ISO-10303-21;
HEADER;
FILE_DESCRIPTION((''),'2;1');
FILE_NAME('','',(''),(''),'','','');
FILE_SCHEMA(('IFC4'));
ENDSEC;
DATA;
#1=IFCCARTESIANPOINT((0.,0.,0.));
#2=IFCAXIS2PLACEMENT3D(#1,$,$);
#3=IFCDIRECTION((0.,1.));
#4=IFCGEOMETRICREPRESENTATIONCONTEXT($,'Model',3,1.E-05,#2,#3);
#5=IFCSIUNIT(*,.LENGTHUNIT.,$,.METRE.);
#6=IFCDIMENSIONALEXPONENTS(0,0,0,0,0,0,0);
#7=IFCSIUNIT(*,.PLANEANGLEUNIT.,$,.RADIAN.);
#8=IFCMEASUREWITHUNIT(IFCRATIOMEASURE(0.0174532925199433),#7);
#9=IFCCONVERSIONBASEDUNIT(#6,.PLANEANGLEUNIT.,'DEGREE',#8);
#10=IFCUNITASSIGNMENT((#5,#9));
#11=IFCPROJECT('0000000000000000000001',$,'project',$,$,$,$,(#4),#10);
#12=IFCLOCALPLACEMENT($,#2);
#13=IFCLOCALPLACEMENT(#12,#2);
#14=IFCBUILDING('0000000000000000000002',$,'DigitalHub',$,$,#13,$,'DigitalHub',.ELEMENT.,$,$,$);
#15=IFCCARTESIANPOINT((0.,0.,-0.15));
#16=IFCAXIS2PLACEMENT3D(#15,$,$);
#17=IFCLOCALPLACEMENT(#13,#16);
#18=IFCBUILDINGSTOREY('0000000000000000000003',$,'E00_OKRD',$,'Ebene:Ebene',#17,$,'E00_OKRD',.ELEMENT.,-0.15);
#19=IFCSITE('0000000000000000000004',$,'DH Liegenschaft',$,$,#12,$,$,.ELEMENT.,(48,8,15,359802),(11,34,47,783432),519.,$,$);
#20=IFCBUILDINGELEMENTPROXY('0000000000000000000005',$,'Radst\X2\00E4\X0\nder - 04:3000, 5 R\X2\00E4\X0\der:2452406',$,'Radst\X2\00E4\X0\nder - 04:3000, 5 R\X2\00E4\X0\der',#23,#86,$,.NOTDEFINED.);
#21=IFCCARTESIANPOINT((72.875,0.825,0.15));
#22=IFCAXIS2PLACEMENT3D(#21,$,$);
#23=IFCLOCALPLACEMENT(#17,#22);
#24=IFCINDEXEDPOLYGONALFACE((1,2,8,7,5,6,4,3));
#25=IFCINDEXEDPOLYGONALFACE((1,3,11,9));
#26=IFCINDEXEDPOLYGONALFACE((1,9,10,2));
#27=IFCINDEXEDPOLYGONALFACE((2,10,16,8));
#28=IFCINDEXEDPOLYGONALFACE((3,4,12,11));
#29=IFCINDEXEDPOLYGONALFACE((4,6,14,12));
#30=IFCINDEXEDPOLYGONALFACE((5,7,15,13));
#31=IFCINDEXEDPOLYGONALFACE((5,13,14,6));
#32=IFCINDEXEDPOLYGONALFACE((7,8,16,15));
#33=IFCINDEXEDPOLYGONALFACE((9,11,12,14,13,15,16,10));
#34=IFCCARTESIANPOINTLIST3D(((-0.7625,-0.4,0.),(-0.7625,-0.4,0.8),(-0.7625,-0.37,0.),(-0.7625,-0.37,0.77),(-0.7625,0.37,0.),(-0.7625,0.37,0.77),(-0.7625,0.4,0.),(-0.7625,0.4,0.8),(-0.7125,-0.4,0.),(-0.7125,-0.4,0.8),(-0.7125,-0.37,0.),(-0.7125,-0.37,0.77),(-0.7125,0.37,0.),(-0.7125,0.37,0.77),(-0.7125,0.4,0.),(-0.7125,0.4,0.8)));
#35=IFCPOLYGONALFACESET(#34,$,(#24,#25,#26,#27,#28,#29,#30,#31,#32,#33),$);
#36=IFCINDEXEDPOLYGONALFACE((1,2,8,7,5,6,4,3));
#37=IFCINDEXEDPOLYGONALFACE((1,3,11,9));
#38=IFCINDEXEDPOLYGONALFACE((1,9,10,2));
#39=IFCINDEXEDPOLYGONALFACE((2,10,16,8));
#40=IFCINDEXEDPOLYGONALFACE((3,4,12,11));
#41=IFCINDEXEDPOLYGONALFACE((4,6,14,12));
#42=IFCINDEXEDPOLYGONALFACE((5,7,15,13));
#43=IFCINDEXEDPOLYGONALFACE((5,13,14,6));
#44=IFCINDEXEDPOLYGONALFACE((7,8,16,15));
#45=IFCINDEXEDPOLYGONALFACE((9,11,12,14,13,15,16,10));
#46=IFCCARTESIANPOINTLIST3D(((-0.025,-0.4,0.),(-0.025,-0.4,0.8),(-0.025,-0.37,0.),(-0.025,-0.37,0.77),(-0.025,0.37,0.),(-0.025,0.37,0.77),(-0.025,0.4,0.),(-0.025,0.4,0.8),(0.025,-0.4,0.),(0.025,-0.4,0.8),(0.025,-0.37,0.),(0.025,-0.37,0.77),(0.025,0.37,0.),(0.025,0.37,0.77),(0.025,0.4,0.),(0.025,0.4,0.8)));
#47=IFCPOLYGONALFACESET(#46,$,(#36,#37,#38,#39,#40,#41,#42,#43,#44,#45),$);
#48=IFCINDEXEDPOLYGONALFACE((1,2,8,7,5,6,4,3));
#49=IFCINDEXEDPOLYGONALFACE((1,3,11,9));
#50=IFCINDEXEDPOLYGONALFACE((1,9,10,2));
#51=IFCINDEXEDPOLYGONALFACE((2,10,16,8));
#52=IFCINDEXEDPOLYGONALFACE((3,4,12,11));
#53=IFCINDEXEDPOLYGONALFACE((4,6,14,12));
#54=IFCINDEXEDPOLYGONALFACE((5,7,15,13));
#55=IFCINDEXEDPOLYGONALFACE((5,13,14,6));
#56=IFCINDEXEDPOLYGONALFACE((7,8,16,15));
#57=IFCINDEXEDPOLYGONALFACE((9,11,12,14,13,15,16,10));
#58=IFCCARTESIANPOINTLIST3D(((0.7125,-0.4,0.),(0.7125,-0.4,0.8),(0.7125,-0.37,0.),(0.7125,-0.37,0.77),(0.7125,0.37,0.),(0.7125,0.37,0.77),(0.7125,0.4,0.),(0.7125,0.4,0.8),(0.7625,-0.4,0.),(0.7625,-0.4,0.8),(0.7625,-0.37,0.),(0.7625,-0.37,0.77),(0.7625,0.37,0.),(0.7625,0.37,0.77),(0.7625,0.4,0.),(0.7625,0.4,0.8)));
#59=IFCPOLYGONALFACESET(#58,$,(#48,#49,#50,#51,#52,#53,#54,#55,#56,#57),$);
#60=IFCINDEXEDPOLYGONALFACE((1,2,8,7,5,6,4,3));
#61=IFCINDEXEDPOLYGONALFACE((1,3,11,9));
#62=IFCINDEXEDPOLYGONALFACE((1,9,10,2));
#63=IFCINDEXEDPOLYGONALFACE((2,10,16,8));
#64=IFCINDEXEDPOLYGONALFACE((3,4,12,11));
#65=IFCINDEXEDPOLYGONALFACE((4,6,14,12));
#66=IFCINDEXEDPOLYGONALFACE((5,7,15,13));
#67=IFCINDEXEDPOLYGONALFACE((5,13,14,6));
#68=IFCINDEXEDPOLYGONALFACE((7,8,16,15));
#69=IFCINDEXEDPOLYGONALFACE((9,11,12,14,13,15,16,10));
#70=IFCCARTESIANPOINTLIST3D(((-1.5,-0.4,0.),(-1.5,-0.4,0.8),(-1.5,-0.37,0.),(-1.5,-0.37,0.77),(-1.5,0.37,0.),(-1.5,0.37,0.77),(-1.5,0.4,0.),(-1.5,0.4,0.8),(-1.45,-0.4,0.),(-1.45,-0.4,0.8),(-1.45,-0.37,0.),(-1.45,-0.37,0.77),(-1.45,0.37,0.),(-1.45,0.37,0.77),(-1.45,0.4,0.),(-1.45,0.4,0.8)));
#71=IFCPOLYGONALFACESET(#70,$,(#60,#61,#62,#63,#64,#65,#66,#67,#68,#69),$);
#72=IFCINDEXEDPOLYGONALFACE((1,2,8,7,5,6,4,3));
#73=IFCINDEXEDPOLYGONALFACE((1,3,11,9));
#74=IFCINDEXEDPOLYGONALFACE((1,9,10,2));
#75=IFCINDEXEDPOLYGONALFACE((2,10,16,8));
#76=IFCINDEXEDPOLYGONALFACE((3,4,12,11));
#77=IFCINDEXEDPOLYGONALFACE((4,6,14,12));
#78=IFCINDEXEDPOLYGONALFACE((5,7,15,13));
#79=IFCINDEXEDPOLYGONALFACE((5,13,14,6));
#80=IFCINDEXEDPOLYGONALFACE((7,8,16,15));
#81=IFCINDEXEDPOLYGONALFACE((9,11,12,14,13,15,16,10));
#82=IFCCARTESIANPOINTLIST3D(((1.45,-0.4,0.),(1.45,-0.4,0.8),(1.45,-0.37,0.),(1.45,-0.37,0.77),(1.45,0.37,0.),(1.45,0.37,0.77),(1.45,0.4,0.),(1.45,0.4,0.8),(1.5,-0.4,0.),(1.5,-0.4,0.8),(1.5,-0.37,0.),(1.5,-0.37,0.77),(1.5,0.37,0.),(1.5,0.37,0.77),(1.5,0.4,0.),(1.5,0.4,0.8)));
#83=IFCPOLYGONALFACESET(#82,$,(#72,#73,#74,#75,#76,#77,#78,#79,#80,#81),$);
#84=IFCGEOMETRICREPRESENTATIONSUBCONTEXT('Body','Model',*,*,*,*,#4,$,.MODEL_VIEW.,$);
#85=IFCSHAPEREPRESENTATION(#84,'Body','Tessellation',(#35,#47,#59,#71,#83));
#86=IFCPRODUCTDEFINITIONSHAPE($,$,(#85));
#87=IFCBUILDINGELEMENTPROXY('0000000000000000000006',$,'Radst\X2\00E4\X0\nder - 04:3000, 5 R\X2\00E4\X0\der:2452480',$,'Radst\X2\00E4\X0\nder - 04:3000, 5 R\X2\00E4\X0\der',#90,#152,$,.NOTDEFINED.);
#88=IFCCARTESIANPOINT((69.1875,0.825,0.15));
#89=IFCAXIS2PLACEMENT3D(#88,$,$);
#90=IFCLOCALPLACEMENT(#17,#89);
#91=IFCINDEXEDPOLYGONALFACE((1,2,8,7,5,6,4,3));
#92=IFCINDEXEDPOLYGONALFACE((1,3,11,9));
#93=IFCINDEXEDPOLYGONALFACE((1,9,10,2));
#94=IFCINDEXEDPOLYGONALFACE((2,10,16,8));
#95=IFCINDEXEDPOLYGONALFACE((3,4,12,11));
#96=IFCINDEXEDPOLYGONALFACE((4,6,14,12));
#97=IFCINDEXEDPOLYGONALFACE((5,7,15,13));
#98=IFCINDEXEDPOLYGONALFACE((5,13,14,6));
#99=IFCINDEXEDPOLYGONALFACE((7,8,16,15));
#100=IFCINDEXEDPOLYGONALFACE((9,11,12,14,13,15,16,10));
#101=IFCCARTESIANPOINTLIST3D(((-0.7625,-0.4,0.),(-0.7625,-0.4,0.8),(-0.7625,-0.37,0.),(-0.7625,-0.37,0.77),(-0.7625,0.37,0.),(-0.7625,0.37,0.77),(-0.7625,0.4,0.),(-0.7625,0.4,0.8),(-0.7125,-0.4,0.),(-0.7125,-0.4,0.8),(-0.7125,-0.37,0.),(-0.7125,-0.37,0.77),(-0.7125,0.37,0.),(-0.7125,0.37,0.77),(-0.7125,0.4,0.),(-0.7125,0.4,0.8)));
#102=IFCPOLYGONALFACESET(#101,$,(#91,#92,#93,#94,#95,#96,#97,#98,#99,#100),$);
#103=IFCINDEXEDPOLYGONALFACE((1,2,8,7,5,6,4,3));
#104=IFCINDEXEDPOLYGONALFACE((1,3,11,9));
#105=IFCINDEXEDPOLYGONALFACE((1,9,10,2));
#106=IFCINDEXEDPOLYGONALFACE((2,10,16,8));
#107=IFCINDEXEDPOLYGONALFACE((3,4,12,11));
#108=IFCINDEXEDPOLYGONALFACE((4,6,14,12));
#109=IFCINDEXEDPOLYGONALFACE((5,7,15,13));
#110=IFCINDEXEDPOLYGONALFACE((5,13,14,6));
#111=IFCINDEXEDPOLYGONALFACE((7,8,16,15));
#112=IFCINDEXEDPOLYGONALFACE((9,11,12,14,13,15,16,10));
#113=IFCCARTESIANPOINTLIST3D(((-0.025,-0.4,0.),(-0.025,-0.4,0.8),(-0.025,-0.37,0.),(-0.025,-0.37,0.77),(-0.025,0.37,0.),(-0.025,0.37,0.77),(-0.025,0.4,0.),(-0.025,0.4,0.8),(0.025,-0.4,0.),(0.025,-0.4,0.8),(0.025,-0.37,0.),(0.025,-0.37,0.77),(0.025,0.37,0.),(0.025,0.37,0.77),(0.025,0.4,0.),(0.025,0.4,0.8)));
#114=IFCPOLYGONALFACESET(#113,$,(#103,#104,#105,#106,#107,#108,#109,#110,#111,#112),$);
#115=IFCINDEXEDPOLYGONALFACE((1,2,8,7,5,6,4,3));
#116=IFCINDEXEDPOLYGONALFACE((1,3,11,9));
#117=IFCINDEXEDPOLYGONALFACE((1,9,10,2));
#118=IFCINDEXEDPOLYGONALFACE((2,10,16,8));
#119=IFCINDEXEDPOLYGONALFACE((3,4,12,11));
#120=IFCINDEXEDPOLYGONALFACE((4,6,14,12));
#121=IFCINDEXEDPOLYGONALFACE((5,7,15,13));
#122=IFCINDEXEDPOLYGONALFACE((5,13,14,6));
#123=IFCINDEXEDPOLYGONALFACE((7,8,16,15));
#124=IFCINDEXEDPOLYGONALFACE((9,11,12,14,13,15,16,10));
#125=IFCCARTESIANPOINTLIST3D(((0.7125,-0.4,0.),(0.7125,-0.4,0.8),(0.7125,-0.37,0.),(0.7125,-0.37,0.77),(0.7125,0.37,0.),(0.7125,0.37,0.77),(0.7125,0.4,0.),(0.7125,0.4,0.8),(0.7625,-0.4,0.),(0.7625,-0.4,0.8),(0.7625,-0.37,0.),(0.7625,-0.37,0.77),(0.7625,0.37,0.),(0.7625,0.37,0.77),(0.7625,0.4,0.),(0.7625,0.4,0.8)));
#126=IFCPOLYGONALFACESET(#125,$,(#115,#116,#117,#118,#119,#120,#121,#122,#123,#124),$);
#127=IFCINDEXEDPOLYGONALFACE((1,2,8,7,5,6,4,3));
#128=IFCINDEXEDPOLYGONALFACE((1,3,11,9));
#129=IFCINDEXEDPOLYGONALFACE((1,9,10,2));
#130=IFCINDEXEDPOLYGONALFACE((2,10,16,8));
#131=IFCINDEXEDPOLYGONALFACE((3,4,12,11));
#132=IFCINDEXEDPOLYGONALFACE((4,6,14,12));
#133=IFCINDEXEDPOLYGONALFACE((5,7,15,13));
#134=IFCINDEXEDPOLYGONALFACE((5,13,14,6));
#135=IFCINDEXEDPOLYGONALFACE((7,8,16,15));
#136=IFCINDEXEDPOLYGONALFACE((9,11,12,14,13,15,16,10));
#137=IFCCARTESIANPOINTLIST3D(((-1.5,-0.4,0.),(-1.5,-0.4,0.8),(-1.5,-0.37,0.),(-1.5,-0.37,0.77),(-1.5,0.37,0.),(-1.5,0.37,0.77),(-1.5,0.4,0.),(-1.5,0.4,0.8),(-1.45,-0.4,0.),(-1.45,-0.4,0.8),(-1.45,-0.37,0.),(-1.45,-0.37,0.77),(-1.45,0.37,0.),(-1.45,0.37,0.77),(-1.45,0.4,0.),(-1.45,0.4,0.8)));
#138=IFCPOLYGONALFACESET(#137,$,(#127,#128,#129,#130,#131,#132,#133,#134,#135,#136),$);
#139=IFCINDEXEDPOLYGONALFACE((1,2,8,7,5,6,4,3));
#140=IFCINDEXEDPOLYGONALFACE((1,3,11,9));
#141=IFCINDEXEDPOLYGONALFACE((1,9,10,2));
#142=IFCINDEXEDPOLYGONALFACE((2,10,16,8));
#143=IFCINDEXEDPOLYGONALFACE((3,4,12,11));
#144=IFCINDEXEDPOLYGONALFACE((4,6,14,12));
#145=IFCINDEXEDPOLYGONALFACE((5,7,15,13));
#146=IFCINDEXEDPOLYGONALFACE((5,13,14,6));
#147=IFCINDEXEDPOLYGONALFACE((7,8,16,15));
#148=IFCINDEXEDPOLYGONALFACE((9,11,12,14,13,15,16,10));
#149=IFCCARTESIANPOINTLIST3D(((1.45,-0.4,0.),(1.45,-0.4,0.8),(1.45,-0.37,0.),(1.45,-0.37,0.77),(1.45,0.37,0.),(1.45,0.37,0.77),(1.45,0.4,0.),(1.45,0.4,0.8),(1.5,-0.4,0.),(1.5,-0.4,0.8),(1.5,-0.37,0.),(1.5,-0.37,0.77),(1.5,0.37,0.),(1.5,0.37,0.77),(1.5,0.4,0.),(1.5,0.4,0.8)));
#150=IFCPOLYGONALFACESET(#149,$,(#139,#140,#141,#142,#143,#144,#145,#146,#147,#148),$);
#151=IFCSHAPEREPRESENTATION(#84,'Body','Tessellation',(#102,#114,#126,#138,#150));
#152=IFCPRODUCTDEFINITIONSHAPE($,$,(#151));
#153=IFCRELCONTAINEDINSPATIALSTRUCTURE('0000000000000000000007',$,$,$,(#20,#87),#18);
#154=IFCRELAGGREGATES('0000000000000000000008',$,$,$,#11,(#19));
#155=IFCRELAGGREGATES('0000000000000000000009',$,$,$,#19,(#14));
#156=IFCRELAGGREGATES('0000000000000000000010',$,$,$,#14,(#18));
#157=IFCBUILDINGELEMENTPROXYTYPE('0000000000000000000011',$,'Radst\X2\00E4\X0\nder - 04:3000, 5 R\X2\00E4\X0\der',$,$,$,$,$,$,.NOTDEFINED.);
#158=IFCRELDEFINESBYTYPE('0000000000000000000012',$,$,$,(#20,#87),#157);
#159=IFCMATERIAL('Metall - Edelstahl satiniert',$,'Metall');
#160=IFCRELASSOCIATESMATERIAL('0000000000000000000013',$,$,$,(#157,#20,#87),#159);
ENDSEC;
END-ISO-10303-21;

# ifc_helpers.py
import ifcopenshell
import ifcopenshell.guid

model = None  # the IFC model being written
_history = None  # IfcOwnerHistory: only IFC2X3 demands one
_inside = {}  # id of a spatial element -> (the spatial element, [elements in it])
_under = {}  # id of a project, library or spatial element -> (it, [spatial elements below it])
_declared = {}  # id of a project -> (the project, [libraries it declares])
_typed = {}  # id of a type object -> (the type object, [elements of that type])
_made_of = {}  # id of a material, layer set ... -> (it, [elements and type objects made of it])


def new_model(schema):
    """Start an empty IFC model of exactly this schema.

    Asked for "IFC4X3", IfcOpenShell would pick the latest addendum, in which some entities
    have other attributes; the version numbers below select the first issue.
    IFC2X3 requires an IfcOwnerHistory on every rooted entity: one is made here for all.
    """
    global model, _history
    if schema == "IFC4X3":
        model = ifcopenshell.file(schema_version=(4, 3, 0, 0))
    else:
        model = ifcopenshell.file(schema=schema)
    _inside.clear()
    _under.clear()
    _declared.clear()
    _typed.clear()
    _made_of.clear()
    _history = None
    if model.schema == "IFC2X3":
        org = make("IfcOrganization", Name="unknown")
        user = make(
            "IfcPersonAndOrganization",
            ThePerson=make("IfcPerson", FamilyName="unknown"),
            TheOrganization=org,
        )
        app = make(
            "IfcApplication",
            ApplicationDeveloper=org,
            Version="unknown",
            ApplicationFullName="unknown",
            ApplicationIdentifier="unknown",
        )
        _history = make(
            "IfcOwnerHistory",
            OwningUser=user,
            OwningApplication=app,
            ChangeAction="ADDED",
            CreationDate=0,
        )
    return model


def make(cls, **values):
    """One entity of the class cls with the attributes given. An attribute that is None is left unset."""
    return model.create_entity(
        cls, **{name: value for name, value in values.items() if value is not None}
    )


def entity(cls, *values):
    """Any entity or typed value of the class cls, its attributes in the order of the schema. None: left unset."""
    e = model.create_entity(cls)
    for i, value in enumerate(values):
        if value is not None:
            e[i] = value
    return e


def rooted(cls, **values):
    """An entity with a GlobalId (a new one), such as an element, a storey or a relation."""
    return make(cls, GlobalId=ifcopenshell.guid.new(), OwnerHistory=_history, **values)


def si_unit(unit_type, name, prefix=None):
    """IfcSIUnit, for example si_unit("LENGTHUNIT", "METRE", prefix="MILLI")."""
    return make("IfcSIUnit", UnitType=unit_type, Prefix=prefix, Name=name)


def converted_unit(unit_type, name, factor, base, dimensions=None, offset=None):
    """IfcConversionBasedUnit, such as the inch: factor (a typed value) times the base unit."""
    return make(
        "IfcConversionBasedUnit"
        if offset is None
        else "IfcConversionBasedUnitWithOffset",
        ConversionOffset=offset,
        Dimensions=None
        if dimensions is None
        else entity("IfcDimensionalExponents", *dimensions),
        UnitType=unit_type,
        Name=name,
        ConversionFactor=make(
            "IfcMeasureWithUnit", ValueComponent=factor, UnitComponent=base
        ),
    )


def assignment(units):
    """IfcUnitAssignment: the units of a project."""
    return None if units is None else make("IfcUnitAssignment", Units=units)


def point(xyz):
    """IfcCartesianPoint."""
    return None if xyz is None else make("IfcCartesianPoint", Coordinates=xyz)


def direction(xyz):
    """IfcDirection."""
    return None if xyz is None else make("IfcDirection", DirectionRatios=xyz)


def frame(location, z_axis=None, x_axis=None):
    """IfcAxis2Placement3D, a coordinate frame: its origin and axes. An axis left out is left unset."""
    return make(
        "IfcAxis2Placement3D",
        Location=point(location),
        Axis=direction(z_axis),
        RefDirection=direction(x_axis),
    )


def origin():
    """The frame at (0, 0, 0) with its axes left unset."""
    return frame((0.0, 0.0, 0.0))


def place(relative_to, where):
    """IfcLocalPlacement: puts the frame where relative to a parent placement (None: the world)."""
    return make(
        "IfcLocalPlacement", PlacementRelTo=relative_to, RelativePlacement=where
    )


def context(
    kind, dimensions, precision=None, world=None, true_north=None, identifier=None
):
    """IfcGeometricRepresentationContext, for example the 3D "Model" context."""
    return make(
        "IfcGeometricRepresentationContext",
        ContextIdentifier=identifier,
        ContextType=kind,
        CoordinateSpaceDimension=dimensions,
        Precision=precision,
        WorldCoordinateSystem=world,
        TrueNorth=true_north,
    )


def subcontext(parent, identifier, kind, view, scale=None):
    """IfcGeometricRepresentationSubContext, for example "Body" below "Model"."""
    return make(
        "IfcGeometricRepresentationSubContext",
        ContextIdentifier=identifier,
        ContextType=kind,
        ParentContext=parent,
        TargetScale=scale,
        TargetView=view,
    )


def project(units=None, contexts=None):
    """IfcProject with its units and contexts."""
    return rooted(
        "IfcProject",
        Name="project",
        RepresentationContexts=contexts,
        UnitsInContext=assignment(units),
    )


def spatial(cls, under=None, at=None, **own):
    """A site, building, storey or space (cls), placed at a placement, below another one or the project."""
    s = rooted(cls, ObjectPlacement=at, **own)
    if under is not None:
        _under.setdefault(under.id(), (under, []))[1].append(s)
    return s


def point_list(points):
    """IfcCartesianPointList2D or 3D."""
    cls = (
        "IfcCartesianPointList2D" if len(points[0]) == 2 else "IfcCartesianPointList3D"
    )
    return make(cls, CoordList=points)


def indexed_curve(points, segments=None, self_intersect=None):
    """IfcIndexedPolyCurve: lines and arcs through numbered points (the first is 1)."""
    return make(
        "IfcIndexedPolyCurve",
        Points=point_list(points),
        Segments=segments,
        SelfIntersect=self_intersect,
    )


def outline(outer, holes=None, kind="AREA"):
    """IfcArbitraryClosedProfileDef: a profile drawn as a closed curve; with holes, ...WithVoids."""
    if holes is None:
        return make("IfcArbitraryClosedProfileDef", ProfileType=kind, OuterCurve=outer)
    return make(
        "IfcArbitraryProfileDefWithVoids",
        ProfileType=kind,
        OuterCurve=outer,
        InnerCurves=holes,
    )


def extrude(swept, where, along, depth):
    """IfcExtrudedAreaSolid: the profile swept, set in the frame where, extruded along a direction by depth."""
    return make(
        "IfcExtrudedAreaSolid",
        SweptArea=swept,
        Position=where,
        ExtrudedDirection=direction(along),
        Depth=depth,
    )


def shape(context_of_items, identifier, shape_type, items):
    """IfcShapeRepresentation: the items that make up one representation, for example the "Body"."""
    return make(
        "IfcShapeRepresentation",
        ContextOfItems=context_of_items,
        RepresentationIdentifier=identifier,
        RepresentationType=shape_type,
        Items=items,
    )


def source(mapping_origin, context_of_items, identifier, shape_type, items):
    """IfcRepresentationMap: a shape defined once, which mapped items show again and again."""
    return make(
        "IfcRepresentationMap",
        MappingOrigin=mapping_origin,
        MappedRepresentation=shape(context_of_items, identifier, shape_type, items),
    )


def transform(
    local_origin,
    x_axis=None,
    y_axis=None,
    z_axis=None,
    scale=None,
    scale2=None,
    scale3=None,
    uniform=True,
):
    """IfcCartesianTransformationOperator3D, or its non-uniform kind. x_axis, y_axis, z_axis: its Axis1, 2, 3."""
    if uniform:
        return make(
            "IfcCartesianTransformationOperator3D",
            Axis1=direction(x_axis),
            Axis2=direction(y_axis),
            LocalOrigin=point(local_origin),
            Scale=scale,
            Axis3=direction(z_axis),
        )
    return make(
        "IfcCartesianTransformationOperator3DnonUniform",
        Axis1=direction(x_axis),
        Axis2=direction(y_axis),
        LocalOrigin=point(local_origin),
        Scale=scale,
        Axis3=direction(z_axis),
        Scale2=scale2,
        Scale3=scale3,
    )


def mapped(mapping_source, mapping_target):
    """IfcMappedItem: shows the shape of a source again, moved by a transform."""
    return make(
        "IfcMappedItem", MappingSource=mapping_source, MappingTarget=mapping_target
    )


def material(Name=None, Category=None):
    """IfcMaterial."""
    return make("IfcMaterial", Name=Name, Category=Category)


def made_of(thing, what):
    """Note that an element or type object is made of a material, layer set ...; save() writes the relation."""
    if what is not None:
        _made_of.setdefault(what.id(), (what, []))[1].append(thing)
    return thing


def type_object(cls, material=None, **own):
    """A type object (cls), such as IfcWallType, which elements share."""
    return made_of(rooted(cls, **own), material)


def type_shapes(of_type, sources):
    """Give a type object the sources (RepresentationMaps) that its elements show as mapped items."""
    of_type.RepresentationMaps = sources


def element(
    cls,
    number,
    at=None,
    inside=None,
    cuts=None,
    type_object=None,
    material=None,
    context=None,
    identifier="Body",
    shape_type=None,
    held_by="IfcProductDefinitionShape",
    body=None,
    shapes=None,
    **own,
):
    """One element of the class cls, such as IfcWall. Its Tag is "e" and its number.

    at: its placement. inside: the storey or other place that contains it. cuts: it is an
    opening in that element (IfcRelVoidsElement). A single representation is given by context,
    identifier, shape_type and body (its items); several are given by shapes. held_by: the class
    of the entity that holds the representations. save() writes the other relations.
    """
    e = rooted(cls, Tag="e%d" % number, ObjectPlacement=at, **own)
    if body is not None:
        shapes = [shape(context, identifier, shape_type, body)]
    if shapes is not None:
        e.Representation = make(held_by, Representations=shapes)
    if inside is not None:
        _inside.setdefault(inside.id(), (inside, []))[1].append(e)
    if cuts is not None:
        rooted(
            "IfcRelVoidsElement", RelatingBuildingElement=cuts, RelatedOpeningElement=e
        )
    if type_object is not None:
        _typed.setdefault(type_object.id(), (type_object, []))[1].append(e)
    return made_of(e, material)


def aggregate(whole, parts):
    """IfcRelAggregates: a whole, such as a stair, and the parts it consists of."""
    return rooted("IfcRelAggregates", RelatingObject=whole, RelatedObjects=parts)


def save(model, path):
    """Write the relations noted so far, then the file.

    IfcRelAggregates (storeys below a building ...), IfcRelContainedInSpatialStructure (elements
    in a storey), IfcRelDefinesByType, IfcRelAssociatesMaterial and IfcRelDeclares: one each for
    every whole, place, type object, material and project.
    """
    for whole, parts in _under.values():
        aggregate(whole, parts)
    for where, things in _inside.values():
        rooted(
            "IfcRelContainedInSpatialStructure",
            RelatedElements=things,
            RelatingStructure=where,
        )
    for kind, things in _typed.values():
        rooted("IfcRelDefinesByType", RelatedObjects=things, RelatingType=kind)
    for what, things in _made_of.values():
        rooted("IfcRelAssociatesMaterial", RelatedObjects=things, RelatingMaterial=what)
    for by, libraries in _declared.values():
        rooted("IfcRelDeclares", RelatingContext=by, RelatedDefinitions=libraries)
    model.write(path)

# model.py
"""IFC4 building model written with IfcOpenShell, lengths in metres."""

from ifc_helpers import new_model, entity, si_unit, converted_unit, direction, frame, origin, place, context, subcontext, project, spatial, indexed_curve, outline, extrude, source, transform, mapped, material, type_object, type_shapes, element, save


model = new_model("IFC4")

# Units and contexts
model_context = context("Model", 3, precision=1e-05, world=origin(), true_north=direction((0.0, 1.0)))
body_context = subcontext(model_context, "Body", "Model", "MODEL_VIEW")
ifc_project = project(units=[si_unit("LENGTHUNIT", "METRE"), converted_unit("PLANEANGLEUNIT", "DEGREE", entity("IfcRatioMeasure", 0.0174532925199433), si_unit("PLANEANGLEUNIT", "RADIAN"), dimensions=[0, 0, 0, 0, 0, 0, 0])], contexts=[model_context])

# Site, building, storey
site_placement = place(None, frame((0.0, 0.0, 0.0)))
site = spatial("IfcSite", under=ifc_project, at=site_placement, Name="DH Liegenschaft", CompositionType="ELEMENT", RefLatitude=(48, 8, 15, 359802), RefLongitude=(11, 34, 47, 783432), RefElevation=519.0)
building_placement = place(site_placement, origin())
building = spatial("IfcBuilding", under=site, at=building_placement, Name="DigitalHub", LongName="DigitalHub", CompositionType="ELEMENT")
storey_placement = place(building_placement, frame((0.0, 0.0, -0.15)))
storey = spatial("IfcBuildingStorey", under=building, at=storey_placement, Name="E00_OKRD", ObjectType="Ebene:Ebene", LongName="E00_OKRD", CompositionType="ELEMENT", Elevation=-0.15)

# Building element proxies
ifc_material_1 = material(Name="Metall - Edelstahl satiniert", Category="Metall")
building_element_proxy_type_1 = type_object("IfcBuildingElementProxyType", Name="Radständer - 04:3000, 5 Räder", PredefinedType="NOTDEFINED", material=ifc_material_1)
shared_shape_1 = source(origin(), body_context, "Body", "SweptSolid", [
    extrude(outline(indexed_curve([(-0.4075, -0.4), (0.3925, -0.4), (0.3925, -0.37), (-0.3775, -0.37), (-0.3775, 0.37), (0.3925, 0.37), (0.3925, 0.4), (-0.4075, 0.4), (-0.4075, -0.4)], self_intersect=False)), frame((-0.7625, 0.0, 0.3925), z_axis=(1.0, 0.0, 0.0), x_axis=(0.0, 0.0, -1.0)), (0.0, 0.0, 1.0), 0.05),
    extrude(outline(indexed_curve([(-0.4075, -0.4), (0.3925, -0.4), (0.3925, -0.37), (-0.3775, -0.37), (-0.3775, 0.37), (0.3925, 0.37), (0.3925, 0.4), (-0.4075, 0.4), (-0.4075, -0.4)], self_intersect=False)), frame((-0.025, 0.0, 0.3925), z_axis=(1.0, 0.0, 0.0), x_axis=(0.0, 0.0, -1.0)), (0.0, 0.0, 1.0), 0.05),
    extrude(outline(indexed_curve([(-0.4075, -0.4), (0.3925, -0.4), (0.3925, -0.37), (-0.3775, -0.37), (-0.3775, 0.37), (0.3925, 0.37), (0.3925, 0.4), (-0.4075, 0.4), (-0.4075, -0.4)], self_intersect=False)), frame((0.7125, 0.0, 0.3925), z_axis=(1.0, 0.0, 0.0), x_axis=(0.0, 0.0, -1.0)), (0.0, 0.0, 1.0), 0.05),
    extrude(outline(indexed_curve([(-0.4075, -0.4), (0.3925, -0.4), (0.3925, -0.37), (-0.3775, -0.37), (-0.3775, 0.37), (0.3925, 0.37), (0.3925, 0.4), (-0.4075, 0.4), (-0.4075, -0.4)], self_intersect=False)), frame((-1.5, 0.0, 0.3925), z_axis=(1.0, 0.0, 0.0), x_axis=(0.0, 0.0, -1.0)), (0.0, 0.0, 1.0), 0.05),
    extrude(outline(indexed_curve([(-0.4075, -0.4), (0.3925, -0.4), (0.3925, -0.37), (-0.3775, -0.37), (-0.3775, 0.37), (0.3925, 0.37), (0.3925, 0.4), (-0.4075, 0.4), (-0.4075, -0.4)], self_intersect=False)), frame((1.45, 0.0, 0.3925), z_axis=(1.0, 0.0, 0.0), x_axis=(0.0, 0.0, -1.0)), (0.0, 0.0, 1.0), 0.05),
])
type_shapes(building_element_proxy_type_1, [shared_shape_1])
for number, where, name in (
    (1, (72.875, 0.825, 0.15), "Radständer - 04:3000, 5 Räder:2452406"),
    (2, (69.1875, 0.825, 0.15), "Radständer - 04:3000, 5 Räder:2452480"),
):
    element("IfcBuildingElementProxy", number, at=place(storey_placement, frame(where)), inside=storey, type_object=building_element_proxy_type_1, material=ifc_material_1, Name=name, ObjectType="Radständer - 04:3000, 5 Räder", PredefinedType="NOTDEFINED", context=body_context, shape_type="MappedRepresentation", body=[
        mapped(shared_shape_1, transform((0.0, 0.0, 0.0), scale=1.0)),
    ])

save(model, "model.ifc")
